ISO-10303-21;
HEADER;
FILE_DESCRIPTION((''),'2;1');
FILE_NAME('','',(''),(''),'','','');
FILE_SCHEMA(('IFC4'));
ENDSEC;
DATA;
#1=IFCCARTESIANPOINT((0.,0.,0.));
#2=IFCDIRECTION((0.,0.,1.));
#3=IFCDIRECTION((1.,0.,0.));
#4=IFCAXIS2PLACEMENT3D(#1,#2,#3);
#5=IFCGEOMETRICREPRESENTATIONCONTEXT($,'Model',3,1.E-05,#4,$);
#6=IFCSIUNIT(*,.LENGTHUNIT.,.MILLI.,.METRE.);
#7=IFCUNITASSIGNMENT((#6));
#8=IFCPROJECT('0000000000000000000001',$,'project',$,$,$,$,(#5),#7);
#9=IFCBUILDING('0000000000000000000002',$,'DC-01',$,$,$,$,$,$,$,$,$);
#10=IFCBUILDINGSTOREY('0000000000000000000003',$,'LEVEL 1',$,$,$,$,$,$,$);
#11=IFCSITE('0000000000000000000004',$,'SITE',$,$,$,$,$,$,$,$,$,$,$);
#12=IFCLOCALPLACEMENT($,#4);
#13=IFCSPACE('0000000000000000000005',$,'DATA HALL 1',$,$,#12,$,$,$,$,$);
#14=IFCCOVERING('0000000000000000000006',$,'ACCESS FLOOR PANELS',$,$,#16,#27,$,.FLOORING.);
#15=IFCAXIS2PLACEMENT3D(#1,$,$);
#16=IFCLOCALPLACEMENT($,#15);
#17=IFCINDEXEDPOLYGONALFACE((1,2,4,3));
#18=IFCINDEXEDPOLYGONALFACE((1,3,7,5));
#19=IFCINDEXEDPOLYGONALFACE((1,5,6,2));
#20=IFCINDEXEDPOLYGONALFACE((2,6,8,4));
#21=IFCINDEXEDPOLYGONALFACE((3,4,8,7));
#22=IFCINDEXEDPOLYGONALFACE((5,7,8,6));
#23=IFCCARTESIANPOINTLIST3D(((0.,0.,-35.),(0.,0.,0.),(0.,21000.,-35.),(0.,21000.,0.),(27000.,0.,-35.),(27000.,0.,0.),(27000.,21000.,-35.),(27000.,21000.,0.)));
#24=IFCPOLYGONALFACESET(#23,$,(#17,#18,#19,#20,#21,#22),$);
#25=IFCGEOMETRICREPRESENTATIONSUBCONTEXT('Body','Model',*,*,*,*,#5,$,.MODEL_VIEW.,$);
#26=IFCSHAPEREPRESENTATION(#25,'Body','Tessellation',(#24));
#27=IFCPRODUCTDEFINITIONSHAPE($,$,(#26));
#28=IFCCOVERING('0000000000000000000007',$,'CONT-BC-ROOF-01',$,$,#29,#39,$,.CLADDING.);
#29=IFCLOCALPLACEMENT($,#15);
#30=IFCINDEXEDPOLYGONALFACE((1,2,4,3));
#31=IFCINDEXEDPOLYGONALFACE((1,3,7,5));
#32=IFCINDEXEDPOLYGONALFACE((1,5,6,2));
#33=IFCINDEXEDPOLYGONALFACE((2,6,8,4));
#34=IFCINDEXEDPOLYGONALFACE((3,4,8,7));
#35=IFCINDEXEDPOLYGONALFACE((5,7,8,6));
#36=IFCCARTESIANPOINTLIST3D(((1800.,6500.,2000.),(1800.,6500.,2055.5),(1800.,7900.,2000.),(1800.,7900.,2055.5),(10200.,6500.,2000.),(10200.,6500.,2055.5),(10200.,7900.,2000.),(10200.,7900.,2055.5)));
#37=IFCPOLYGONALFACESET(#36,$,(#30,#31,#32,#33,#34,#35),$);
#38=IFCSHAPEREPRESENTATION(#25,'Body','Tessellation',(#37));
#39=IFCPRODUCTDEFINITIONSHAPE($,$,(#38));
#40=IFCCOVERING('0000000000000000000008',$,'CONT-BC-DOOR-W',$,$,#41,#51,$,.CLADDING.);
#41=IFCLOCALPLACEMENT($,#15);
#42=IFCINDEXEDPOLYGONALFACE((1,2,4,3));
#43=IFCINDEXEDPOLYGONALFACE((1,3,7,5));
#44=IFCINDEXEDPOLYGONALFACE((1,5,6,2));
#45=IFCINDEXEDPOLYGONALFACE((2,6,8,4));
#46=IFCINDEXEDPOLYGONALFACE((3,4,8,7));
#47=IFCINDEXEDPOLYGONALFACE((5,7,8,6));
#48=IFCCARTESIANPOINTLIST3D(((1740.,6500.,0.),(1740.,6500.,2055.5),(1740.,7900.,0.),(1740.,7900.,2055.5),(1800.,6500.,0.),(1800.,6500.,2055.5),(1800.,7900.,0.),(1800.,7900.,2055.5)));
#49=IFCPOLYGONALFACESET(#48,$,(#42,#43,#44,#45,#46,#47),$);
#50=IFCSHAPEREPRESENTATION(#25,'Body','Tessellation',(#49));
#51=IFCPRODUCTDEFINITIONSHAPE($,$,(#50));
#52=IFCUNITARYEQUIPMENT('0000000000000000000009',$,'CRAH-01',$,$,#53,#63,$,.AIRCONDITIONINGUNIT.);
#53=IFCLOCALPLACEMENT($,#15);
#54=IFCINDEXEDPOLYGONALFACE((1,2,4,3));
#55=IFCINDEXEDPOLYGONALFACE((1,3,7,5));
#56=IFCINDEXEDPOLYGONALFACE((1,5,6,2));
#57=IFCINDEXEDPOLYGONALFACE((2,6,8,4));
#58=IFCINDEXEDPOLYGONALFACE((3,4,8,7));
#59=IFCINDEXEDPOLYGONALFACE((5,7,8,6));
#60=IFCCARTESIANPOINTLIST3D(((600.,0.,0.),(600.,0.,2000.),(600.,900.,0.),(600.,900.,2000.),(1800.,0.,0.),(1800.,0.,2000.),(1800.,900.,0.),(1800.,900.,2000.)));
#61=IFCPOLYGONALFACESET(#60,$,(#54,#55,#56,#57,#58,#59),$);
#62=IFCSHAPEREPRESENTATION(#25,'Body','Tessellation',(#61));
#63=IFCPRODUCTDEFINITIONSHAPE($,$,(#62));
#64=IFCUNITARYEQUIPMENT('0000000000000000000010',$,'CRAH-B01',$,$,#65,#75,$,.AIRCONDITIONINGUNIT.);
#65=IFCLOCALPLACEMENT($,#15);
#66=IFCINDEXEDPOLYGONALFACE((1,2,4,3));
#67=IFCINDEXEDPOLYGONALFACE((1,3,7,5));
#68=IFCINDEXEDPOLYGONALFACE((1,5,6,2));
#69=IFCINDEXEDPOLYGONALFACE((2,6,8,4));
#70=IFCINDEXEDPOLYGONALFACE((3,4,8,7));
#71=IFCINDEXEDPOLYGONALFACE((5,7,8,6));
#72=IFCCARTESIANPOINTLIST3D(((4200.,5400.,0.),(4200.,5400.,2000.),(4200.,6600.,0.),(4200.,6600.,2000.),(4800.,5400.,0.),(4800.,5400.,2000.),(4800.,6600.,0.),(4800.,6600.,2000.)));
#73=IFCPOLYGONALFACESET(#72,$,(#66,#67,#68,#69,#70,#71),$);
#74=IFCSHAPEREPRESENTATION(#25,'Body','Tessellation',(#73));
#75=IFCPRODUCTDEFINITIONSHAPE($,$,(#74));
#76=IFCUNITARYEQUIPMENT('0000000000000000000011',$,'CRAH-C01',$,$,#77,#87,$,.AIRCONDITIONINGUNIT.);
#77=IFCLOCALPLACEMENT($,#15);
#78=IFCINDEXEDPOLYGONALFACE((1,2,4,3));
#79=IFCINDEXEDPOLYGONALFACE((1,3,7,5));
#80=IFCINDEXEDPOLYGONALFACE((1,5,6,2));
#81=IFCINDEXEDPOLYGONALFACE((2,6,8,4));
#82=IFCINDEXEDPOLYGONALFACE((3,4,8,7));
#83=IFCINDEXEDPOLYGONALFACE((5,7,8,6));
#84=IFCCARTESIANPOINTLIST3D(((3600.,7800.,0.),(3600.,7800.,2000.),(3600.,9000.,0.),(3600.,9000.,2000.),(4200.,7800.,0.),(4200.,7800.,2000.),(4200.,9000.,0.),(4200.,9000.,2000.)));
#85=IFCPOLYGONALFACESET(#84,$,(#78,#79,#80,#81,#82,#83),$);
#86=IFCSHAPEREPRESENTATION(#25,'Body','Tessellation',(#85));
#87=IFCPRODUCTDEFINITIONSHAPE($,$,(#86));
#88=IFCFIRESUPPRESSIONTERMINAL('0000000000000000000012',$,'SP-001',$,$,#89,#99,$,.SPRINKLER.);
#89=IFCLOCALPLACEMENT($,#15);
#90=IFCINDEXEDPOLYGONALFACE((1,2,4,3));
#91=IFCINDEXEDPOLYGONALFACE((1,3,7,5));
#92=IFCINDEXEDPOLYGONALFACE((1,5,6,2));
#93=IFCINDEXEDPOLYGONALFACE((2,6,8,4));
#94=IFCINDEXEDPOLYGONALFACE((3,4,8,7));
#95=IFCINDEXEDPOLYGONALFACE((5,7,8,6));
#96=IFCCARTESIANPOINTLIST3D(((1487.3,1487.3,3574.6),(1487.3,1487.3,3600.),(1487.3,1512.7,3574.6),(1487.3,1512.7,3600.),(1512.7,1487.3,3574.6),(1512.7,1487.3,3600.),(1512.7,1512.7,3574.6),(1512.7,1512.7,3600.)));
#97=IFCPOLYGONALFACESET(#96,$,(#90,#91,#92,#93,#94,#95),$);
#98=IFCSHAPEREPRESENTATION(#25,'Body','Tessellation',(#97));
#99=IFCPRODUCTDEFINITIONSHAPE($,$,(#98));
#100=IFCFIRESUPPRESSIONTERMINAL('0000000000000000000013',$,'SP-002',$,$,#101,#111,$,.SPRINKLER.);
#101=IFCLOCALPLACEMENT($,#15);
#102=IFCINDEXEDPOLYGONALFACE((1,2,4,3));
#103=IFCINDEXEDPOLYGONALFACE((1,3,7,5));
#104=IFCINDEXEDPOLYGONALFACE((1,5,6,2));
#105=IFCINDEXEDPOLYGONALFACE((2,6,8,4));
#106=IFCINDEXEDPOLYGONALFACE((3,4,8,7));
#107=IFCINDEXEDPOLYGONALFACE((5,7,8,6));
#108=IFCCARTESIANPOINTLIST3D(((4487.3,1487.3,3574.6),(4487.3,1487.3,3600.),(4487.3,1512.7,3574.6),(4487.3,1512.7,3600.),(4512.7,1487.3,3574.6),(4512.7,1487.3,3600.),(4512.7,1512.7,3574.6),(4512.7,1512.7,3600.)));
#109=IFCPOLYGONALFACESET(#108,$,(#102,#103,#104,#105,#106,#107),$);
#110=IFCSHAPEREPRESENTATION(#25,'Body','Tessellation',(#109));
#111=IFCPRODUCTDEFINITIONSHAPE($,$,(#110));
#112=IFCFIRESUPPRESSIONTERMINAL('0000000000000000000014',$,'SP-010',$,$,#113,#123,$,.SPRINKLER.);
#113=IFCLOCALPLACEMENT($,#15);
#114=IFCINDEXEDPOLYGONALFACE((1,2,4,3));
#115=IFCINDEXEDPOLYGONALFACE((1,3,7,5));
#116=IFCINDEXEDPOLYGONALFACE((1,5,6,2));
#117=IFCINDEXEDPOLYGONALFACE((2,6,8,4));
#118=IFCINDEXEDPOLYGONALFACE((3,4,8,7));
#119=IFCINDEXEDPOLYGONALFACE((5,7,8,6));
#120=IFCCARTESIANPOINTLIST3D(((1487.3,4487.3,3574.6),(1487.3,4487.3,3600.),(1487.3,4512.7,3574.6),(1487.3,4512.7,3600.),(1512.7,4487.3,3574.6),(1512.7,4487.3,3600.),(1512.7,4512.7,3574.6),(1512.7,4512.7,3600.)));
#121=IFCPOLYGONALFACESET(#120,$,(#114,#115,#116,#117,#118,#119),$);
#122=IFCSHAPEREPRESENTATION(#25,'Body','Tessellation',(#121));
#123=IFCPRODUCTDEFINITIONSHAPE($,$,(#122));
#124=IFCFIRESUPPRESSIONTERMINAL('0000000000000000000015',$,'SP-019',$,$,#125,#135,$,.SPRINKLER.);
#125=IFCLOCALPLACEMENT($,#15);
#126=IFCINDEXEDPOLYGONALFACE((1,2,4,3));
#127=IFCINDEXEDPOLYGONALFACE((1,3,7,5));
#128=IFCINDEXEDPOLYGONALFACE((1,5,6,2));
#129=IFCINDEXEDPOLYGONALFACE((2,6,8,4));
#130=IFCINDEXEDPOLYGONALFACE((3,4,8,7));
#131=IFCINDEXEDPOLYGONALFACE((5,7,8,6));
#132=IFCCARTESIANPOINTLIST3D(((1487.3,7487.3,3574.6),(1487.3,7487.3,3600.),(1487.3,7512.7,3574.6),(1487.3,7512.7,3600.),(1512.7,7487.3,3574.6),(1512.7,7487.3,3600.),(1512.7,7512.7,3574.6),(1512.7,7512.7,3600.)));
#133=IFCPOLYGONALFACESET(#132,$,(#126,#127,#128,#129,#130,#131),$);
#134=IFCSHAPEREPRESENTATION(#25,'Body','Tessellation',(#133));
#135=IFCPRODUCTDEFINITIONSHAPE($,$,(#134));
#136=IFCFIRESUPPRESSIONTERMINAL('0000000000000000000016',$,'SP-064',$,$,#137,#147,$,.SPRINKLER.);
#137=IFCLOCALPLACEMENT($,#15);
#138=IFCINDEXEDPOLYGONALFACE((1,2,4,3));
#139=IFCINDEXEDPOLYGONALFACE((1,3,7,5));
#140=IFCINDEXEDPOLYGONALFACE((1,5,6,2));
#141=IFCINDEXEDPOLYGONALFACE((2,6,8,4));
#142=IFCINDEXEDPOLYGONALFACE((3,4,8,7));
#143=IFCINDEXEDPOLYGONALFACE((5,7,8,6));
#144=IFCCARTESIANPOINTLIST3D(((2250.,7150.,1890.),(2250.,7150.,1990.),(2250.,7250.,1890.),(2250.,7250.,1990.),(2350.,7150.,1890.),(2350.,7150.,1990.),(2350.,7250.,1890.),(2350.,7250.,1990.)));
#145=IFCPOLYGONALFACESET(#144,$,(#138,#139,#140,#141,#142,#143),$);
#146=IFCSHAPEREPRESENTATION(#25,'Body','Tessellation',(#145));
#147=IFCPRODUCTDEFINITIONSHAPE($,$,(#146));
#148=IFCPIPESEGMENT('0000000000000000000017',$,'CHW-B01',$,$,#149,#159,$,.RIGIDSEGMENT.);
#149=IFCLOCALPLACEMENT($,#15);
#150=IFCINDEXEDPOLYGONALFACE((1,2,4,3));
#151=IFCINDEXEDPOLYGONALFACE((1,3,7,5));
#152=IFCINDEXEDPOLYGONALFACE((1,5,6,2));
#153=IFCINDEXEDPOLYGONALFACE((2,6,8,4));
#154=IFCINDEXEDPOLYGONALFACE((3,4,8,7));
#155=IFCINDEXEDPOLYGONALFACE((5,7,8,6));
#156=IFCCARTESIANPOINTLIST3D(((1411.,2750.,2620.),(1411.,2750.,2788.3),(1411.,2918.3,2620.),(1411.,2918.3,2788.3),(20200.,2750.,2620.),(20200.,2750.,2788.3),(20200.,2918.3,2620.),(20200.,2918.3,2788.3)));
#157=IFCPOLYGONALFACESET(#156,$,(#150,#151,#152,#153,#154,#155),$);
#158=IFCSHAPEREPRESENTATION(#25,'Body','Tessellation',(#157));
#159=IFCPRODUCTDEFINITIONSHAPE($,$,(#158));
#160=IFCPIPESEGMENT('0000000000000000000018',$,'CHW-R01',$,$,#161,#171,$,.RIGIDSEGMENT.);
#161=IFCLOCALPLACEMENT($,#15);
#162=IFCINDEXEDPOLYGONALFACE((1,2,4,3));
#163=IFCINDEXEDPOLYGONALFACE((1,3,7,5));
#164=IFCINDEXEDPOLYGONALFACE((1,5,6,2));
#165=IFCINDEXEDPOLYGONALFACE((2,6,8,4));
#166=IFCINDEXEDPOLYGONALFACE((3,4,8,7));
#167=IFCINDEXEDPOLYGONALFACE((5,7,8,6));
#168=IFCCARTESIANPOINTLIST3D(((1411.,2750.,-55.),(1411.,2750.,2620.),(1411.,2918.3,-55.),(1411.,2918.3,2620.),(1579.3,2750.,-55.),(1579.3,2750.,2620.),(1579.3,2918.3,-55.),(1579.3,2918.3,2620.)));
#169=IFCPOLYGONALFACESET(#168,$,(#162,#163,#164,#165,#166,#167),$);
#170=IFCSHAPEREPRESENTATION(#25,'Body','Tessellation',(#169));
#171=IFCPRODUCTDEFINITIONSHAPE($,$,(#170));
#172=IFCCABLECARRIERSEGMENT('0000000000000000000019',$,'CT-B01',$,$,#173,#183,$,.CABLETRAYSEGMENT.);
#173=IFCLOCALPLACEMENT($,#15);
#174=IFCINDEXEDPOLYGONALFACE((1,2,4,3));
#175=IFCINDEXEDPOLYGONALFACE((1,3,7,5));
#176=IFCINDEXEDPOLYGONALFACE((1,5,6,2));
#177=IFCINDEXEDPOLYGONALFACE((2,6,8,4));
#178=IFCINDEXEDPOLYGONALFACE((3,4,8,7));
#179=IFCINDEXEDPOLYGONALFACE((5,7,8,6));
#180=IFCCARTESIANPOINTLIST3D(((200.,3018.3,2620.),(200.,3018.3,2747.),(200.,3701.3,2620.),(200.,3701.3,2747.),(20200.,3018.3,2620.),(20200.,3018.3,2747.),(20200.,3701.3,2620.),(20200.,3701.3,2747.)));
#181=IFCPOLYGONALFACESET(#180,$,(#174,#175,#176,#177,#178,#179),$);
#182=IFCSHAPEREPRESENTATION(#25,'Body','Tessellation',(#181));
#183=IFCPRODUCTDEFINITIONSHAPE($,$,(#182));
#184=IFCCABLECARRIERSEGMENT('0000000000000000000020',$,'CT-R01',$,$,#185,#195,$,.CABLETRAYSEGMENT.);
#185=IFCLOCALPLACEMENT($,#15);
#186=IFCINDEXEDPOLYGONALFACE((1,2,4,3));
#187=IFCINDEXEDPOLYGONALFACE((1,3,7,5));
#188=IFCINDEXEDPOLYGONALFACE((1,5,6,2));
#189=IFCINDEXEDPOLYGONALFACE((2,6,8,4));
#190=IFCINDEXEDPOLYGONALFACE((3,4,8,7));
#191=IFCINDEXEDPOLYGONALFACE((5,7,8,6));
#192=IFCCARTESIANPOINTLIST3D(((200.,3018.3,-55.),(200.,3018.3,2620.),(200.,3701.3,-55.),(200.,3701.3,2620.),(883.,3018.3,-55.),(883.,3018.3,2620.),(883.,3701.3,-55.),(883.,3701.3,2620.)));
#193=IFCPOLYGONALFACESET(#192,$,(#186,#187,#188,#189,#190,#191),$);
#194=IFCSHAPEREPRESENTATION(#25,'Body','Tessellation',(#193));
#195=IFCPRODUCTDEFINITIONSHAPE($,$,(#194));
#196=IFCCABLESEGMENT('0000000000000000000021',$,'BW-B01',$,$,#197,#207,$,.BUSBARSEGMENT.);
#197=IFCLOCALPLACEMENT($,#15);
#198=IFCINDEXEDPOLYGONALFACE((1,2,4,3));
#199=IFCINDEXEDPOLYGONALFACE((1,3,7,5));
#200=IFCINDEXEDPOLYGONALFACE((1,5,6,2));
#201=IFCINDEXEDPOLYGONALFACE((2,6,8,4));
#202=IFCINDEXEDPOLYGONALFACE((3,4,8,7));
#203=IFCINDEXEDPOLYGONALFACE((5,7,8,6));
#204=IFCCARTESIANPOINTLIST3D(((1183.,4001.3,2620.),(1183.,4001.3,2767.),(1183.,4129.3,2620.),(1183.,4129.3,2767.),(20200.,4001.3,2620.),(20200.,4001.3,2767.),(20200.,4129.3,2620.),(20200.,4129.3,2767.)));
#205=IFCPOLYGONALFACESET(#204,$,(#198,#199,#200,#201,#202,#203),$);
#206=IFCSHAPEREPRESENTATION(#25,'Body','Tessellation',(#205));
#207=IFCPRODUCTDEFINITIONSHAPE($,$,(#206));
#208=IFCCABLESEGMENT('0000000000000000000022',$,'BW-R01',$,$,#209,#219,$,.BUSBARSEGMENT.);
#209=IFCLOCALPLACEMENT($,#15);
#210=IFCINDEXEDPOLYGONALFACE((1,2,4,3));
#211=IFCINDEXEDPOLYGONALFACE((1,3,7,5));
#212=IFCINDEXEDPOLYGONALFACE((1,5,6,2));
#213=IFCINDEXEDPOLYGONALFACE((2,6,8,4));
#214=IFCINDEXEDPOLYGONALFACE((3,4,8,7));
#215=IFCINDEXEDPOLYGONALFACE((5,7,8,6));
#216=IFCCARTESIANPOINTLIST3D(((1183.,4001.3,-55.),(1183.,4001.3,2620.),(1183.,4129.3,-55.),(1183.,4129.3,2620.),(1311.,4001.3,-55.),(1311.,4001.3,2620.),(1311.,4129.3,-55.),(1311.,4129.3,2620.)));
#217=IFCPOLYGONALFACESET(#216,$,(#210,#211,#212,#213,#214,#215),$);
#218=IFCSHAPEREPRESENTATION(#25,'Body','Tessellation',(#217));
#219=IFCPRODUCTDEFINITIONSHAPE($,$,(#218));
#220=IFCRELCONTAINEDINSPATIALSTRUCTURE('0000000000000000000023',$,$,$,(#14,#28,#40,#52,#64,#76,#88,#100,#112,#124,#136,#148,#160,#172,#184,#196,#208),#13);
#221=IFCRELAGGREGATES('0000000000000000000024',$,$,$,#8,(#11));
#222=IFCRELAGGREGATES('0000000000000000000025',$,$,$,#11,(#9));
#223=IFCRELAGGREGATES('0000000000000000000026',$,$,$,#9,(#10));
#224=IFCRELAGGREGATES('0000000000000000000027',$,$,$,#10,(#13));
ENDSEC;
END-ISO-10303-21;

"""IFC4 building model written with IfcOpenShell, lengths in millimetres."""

from ifc_helpers import new_model, si_unit, frame, origin, origin_with_axes, place, context, subcontext, project, spatial, polyline, outline, extrude, element, save


model = new_model("IFC4")

# Units and contexts
model_context = context("Model", 3, precision=1e-05, world=origin_with_axes())
body_context = subcontext(model_context, "Body", "Model", "MODEL_VIEW")
ifc_project = project(units=[si_unit("LENGTHUNIT", "METRE", prefix="MILLI")], contexts=[model_context])

# Site, building, storey, space
site = spatial("IfcSite", under=ifc_project, Name="SITE")
building = spatial("IfcBuilding", under=site, Name="DC-01")
storey = spatial("IfcBuildingStorey", under=building, Name="LEVEL 1")
space_placement = place(None, origin_with_axes())
space = spatial("IfcSpace", under=storey, at=space_placement, Name="DATA HALL 1")

# Coverings
covering_1_placement = place(space_placement, frame((0.0, 0.0, -35.0), z_axis=(0.0, 0.0, 1.0), x_axis=(1.0, 0.0, 0.0)))
element("IfcCovering", 1, at=covering_1_placement, inside=space, Name="ACCESS FLOOR PANELS", PredefinedType="FLOORING", context=body_context, shape_type="SweptSolid", body=[
    extrude(outline(polyline([(0.0, 0.0), (27000.0, 0.0), (27000.0, 21000.0), (0.0, 21000.0), (0.0, 0.0)])), origin(), (0.0, 0.0, 1.0), 35.0),
])
covering_2_placement = place(space_placement, frame((1800.0, 6500.0, 2000.0), z_axis=(0.0, 0.0, 1.0), x_axis=(1.0, 0.0, 0.0)))
element("IfcCovering", 2, at=covering_2_placement, inside=space, Name="CONT-BC-ROOF-01", PredefinedType="CLADDING", context=body_context, shape_type="SweptSolid", body=[
    extrude(outline(polyline([(0.0, 0.0), (8400.0, 0.0), (8400.0, 1400.0), (0.0, 1400.0), (0.0, 0.0)])), origin(), (0.0, 0.0, 1.0), 55.5),
])
covering_3_placement = place(space_placement, frame((1740.0, 6500.0, 0.0), z_axis=(0.0, 0.0, 1.0), x_axis=(1.0, 0.0, 0.0)))
element("IfcCovering", 3, at=covering_3_placement, inside=space, Name="CONT-BC-DOOR-W", PredefinedType="CLADDING", context=body_context, shape_type="SweptSolid", body=[
    extrude(outline(polyline([(0.0, 0.0), (60.0, 0.0), (60.0, 1400.0), (0.0, 1400.0), (0.0, 0.0)])), origin(), (0.0, 0.0, 1.0), 2055.5),
])

# Unitary equipment
unitary_equipment_placement = place(space_placement, frame((600.0, 0.0, 0.0), z_axis=(0.0, 0.0, 1.0), x_axis=(1.0, 0.0, 0.0)))
element("IfcUnitaryEquipment", 4, at=unitary_equipment_placement, inside=space, Name="CRAH-01", PredefinedType="AIRCONDITIONINGUNIT", context=body_context, shape_type="SweptSolid", body=[
    extrude(outline(polyline([(0.0, 0.0), (1200.0, 0.0), (1200.0, 900.0), (0.0, 900.0), (0.0, 0.0)])), origin(), (0.0, 0.0, 1.0), 2000.0),
])
for number, where, z_axis, x_axis, name in (
    (5, (4200.0, 5400.0, 0.0), (0.0, 0.0, 1.0), (1.0, 0.0, 0.0), "CRAH-B01"),
    (6, (4200.0, 9000.0, 0.0), (0.0, 0.0, 1.0), (-1.0, 0.0, 0.0), "CRAH-C01"),
):
    element("IfcUnitaryEquipment", number, at=place(space_placement, frame(where, z_axis=z_axis, x_axis=x_axis)), inside=space, Name=name, PredefinedType="AIRCONDITIONINGUNIT", context=body_context, shape_type="SweptSolid", body=[
        extrude(outline(polyline([(0.0, 0.0), (600.0, 0.0), (600.0, 1200.0), (0.0, 1200.0), (0.0, 0.0)])), origin(), (0.0, 0.0, 1.0), 2000.0),
    ])

# Fire suppression terminals
for number, where, z_axis, x_axis, name in (
    (7, (1487.3, 1487.3, 3574.6), (0.0, 0.0, 1.0), (1.0, 0.0, 0.0), "SP-001"),
    (8, (4487.3, 1487.3, 3574.6), (0.0, 0.0, 1.0), (1.0, 0.0, 0.0), "SP-002"),
    (9, (1487.3, 4487.3, 3574.6), (0.0, 0.0, 1.0), (1.0, 0.0, 0.0), "SP-010"),
    (10, (1487.3, 7487.3, 3574.6), (0.0, 0.0, 1.0), (1.0, 0.0, 0.0), "SP-019"),
):
    element("IfcFireSuppressionTerminal", number, at=place(space_placement, frame(where, z_axis=z_axis, x_axis=x_axis)), inside=space, Name=name, PredefinedType="SPRINKLER", context=body_context, shape_type="SweptSolid", body=[
        extrude(outline(polyline([(0.0, 0.0), (25.4, 0.0), (25.4, 25.4), (0.0, 25.4), (0.0, 0.0)])), origin(), (0.0, 0.0, 1.0), 25.4),
    ])
fire_suppression_terminal_placement = place(space_placement, frame((2250.0, 7150.0, 1890.0), z_axis=(0.0, 0.0, 1.0), x_axis=(1.0, 0.0, 0.0)))
element("IfcFireSuppressionTerminal", 11, at=fire_suppression_terminal_placement, inside=space, Name="SP-064", PredefinedType="SPRINKLER", context=body_context, shape_type="SweptSolid", body=[
    extrude(outline(polyline([(0.0, 0.0), (100.0, 0.0), (100.0, 100.0), (0.0, 100.0), (0.0, 0.0)])), origin(), (0.0, 0.0, 1.0), 100.0),
])

# Pipe segments
pipe_segment_1_placement = place(space_placement, frame((1411.0, 2750.0, 2620.0), z_axis=(0.0, 0.0, 1.0), x_axis=(1.0, 0.0, 0.0)))
element("IfcPipeSegment", 12, at=pipe_segment_1_placement, inside=space, Name="CHW-B01", PredefinedType="RIGIDSEGMENT", context=body_context, shape_type="SweptSolid", body=[
    extrude(outline(polyline([(0.0, 0.0), (18789.0, 0.0), (18789.0, 168.3), (0.0, 168.3), (0.0, 0.0)])), origin(), (0.0, 0.0, 1.0), 168.3),
])
pipe_segment_2_placement = place(space_placement, frame((1411.0, 2750.0, -55.0), z_axis=(0.0, 0.0, 1.0), x_axis=(1.0, 0.0, 0.0)))
element("IfcPipeSegment", 13, at=pipe_segment_2_placement, inside=space, Name="CHW-R01", PredefinedType="RIGIDSEGMENT", context=body_context, shape_type="SweptSolid", body=[
    extrude(outline(polyline([(0.0, 0.0), (168.3, 0.0), (168.3, 168.3), (0.0, 168.3), (0.0, 0.0)])), origin(), (0.0, 0.0, 1.0), 2675.0),
])

# Cable carrier segments
cable_carrier_segment_1_placement = place(space_placement, frame((200.0, 3018.3, 2620.0), z_axis=(0.0, 0.0, 1.0), x_axis=(1.0, 0.0, 0.0)))
element("IfcCableCarrierSegment", 14, at=cable_carrier_segment_1_placement, inside=space, Name="CT-B01", PredefinedType="CABLETRAYSEGMENT", context=body_context, shape_type="SweptSolid", body=[
    extrude(outline(polyline([(0.0, 0.0), (20000.0, 0.0), (20000.0, 683.0), (0.0, 683.0), (0.0, 0.0)])), origin(), (0.0, 0.0, 1.0), 127.0),
])
cable_carrier_segment_2_placement = place(space_placement, frame((200.0, 3018.3, -55.0), z_axis=(0.0, 0.0, 1.0), x_axis=(1.0, 0.0, 0.0)))
element("IfcCableCarrierSegment", 15, at=cable_carrier_segment_2_placement, inside=space, Name="CT-R01", PredefinedType="CABLETRAYSEGMENT", context=body_context, shape_type="SweptSolid", body=[
    extrude(outline(polyline([(0.0, 0.0), (683.0, 0.0), (683.0, 683.0), (0.0, 683.0), (0.0, 0.0)])), origin(), (0.0, 0.0, 1.0), 2675.0),
])

# Cable segments
cable_segment_1_placement = place(space_placement, frame((1183.0, 4001.3, 2620.0), z_axis=(0.0, 0.0, 1.0), x_axis=(1.0, 0.0, 0.0)))
element("IfcCableSegment", 16, at=cable_segment_1_placement, inside=space, Name="BW-B01", PredefinedType="BUSBARSEGMENT", context=body_context, shape_type="SweptSolid", body=[
    extrude(outline(polyline([(0.0, 0.0), (19017.0, 0.0), (19017.0, 128.0), (0.0, 128.0), (0.0, 0.0)])), origin(), (0.0, 0.0, 1.0), 147.0),
])
cable_segment_2_placement = place(space_placement, frame((1183.0, 4001.3, -55.0), z_axis=(0.0, 0.0, 1.0), x_axis=(1.0, 0.0, 0.0)))
element("IfcCableSegment", 17, at=cable_segment_2_placement, inside=space, Name="BW-R01", PredefinedType="BUSBARSEGMENT", context=body_context, shape_type="SweptSolid", body=[
    extrude(outline(polyline([(0.0, 0.0), (128.0, 0.0), (128.0, 128.0), (0.0, 128.0), (0.0, 0.0)])), origin(), (0.0, 0.0, 1.0), 2675.0),
])

save(model, "model.ifc")
